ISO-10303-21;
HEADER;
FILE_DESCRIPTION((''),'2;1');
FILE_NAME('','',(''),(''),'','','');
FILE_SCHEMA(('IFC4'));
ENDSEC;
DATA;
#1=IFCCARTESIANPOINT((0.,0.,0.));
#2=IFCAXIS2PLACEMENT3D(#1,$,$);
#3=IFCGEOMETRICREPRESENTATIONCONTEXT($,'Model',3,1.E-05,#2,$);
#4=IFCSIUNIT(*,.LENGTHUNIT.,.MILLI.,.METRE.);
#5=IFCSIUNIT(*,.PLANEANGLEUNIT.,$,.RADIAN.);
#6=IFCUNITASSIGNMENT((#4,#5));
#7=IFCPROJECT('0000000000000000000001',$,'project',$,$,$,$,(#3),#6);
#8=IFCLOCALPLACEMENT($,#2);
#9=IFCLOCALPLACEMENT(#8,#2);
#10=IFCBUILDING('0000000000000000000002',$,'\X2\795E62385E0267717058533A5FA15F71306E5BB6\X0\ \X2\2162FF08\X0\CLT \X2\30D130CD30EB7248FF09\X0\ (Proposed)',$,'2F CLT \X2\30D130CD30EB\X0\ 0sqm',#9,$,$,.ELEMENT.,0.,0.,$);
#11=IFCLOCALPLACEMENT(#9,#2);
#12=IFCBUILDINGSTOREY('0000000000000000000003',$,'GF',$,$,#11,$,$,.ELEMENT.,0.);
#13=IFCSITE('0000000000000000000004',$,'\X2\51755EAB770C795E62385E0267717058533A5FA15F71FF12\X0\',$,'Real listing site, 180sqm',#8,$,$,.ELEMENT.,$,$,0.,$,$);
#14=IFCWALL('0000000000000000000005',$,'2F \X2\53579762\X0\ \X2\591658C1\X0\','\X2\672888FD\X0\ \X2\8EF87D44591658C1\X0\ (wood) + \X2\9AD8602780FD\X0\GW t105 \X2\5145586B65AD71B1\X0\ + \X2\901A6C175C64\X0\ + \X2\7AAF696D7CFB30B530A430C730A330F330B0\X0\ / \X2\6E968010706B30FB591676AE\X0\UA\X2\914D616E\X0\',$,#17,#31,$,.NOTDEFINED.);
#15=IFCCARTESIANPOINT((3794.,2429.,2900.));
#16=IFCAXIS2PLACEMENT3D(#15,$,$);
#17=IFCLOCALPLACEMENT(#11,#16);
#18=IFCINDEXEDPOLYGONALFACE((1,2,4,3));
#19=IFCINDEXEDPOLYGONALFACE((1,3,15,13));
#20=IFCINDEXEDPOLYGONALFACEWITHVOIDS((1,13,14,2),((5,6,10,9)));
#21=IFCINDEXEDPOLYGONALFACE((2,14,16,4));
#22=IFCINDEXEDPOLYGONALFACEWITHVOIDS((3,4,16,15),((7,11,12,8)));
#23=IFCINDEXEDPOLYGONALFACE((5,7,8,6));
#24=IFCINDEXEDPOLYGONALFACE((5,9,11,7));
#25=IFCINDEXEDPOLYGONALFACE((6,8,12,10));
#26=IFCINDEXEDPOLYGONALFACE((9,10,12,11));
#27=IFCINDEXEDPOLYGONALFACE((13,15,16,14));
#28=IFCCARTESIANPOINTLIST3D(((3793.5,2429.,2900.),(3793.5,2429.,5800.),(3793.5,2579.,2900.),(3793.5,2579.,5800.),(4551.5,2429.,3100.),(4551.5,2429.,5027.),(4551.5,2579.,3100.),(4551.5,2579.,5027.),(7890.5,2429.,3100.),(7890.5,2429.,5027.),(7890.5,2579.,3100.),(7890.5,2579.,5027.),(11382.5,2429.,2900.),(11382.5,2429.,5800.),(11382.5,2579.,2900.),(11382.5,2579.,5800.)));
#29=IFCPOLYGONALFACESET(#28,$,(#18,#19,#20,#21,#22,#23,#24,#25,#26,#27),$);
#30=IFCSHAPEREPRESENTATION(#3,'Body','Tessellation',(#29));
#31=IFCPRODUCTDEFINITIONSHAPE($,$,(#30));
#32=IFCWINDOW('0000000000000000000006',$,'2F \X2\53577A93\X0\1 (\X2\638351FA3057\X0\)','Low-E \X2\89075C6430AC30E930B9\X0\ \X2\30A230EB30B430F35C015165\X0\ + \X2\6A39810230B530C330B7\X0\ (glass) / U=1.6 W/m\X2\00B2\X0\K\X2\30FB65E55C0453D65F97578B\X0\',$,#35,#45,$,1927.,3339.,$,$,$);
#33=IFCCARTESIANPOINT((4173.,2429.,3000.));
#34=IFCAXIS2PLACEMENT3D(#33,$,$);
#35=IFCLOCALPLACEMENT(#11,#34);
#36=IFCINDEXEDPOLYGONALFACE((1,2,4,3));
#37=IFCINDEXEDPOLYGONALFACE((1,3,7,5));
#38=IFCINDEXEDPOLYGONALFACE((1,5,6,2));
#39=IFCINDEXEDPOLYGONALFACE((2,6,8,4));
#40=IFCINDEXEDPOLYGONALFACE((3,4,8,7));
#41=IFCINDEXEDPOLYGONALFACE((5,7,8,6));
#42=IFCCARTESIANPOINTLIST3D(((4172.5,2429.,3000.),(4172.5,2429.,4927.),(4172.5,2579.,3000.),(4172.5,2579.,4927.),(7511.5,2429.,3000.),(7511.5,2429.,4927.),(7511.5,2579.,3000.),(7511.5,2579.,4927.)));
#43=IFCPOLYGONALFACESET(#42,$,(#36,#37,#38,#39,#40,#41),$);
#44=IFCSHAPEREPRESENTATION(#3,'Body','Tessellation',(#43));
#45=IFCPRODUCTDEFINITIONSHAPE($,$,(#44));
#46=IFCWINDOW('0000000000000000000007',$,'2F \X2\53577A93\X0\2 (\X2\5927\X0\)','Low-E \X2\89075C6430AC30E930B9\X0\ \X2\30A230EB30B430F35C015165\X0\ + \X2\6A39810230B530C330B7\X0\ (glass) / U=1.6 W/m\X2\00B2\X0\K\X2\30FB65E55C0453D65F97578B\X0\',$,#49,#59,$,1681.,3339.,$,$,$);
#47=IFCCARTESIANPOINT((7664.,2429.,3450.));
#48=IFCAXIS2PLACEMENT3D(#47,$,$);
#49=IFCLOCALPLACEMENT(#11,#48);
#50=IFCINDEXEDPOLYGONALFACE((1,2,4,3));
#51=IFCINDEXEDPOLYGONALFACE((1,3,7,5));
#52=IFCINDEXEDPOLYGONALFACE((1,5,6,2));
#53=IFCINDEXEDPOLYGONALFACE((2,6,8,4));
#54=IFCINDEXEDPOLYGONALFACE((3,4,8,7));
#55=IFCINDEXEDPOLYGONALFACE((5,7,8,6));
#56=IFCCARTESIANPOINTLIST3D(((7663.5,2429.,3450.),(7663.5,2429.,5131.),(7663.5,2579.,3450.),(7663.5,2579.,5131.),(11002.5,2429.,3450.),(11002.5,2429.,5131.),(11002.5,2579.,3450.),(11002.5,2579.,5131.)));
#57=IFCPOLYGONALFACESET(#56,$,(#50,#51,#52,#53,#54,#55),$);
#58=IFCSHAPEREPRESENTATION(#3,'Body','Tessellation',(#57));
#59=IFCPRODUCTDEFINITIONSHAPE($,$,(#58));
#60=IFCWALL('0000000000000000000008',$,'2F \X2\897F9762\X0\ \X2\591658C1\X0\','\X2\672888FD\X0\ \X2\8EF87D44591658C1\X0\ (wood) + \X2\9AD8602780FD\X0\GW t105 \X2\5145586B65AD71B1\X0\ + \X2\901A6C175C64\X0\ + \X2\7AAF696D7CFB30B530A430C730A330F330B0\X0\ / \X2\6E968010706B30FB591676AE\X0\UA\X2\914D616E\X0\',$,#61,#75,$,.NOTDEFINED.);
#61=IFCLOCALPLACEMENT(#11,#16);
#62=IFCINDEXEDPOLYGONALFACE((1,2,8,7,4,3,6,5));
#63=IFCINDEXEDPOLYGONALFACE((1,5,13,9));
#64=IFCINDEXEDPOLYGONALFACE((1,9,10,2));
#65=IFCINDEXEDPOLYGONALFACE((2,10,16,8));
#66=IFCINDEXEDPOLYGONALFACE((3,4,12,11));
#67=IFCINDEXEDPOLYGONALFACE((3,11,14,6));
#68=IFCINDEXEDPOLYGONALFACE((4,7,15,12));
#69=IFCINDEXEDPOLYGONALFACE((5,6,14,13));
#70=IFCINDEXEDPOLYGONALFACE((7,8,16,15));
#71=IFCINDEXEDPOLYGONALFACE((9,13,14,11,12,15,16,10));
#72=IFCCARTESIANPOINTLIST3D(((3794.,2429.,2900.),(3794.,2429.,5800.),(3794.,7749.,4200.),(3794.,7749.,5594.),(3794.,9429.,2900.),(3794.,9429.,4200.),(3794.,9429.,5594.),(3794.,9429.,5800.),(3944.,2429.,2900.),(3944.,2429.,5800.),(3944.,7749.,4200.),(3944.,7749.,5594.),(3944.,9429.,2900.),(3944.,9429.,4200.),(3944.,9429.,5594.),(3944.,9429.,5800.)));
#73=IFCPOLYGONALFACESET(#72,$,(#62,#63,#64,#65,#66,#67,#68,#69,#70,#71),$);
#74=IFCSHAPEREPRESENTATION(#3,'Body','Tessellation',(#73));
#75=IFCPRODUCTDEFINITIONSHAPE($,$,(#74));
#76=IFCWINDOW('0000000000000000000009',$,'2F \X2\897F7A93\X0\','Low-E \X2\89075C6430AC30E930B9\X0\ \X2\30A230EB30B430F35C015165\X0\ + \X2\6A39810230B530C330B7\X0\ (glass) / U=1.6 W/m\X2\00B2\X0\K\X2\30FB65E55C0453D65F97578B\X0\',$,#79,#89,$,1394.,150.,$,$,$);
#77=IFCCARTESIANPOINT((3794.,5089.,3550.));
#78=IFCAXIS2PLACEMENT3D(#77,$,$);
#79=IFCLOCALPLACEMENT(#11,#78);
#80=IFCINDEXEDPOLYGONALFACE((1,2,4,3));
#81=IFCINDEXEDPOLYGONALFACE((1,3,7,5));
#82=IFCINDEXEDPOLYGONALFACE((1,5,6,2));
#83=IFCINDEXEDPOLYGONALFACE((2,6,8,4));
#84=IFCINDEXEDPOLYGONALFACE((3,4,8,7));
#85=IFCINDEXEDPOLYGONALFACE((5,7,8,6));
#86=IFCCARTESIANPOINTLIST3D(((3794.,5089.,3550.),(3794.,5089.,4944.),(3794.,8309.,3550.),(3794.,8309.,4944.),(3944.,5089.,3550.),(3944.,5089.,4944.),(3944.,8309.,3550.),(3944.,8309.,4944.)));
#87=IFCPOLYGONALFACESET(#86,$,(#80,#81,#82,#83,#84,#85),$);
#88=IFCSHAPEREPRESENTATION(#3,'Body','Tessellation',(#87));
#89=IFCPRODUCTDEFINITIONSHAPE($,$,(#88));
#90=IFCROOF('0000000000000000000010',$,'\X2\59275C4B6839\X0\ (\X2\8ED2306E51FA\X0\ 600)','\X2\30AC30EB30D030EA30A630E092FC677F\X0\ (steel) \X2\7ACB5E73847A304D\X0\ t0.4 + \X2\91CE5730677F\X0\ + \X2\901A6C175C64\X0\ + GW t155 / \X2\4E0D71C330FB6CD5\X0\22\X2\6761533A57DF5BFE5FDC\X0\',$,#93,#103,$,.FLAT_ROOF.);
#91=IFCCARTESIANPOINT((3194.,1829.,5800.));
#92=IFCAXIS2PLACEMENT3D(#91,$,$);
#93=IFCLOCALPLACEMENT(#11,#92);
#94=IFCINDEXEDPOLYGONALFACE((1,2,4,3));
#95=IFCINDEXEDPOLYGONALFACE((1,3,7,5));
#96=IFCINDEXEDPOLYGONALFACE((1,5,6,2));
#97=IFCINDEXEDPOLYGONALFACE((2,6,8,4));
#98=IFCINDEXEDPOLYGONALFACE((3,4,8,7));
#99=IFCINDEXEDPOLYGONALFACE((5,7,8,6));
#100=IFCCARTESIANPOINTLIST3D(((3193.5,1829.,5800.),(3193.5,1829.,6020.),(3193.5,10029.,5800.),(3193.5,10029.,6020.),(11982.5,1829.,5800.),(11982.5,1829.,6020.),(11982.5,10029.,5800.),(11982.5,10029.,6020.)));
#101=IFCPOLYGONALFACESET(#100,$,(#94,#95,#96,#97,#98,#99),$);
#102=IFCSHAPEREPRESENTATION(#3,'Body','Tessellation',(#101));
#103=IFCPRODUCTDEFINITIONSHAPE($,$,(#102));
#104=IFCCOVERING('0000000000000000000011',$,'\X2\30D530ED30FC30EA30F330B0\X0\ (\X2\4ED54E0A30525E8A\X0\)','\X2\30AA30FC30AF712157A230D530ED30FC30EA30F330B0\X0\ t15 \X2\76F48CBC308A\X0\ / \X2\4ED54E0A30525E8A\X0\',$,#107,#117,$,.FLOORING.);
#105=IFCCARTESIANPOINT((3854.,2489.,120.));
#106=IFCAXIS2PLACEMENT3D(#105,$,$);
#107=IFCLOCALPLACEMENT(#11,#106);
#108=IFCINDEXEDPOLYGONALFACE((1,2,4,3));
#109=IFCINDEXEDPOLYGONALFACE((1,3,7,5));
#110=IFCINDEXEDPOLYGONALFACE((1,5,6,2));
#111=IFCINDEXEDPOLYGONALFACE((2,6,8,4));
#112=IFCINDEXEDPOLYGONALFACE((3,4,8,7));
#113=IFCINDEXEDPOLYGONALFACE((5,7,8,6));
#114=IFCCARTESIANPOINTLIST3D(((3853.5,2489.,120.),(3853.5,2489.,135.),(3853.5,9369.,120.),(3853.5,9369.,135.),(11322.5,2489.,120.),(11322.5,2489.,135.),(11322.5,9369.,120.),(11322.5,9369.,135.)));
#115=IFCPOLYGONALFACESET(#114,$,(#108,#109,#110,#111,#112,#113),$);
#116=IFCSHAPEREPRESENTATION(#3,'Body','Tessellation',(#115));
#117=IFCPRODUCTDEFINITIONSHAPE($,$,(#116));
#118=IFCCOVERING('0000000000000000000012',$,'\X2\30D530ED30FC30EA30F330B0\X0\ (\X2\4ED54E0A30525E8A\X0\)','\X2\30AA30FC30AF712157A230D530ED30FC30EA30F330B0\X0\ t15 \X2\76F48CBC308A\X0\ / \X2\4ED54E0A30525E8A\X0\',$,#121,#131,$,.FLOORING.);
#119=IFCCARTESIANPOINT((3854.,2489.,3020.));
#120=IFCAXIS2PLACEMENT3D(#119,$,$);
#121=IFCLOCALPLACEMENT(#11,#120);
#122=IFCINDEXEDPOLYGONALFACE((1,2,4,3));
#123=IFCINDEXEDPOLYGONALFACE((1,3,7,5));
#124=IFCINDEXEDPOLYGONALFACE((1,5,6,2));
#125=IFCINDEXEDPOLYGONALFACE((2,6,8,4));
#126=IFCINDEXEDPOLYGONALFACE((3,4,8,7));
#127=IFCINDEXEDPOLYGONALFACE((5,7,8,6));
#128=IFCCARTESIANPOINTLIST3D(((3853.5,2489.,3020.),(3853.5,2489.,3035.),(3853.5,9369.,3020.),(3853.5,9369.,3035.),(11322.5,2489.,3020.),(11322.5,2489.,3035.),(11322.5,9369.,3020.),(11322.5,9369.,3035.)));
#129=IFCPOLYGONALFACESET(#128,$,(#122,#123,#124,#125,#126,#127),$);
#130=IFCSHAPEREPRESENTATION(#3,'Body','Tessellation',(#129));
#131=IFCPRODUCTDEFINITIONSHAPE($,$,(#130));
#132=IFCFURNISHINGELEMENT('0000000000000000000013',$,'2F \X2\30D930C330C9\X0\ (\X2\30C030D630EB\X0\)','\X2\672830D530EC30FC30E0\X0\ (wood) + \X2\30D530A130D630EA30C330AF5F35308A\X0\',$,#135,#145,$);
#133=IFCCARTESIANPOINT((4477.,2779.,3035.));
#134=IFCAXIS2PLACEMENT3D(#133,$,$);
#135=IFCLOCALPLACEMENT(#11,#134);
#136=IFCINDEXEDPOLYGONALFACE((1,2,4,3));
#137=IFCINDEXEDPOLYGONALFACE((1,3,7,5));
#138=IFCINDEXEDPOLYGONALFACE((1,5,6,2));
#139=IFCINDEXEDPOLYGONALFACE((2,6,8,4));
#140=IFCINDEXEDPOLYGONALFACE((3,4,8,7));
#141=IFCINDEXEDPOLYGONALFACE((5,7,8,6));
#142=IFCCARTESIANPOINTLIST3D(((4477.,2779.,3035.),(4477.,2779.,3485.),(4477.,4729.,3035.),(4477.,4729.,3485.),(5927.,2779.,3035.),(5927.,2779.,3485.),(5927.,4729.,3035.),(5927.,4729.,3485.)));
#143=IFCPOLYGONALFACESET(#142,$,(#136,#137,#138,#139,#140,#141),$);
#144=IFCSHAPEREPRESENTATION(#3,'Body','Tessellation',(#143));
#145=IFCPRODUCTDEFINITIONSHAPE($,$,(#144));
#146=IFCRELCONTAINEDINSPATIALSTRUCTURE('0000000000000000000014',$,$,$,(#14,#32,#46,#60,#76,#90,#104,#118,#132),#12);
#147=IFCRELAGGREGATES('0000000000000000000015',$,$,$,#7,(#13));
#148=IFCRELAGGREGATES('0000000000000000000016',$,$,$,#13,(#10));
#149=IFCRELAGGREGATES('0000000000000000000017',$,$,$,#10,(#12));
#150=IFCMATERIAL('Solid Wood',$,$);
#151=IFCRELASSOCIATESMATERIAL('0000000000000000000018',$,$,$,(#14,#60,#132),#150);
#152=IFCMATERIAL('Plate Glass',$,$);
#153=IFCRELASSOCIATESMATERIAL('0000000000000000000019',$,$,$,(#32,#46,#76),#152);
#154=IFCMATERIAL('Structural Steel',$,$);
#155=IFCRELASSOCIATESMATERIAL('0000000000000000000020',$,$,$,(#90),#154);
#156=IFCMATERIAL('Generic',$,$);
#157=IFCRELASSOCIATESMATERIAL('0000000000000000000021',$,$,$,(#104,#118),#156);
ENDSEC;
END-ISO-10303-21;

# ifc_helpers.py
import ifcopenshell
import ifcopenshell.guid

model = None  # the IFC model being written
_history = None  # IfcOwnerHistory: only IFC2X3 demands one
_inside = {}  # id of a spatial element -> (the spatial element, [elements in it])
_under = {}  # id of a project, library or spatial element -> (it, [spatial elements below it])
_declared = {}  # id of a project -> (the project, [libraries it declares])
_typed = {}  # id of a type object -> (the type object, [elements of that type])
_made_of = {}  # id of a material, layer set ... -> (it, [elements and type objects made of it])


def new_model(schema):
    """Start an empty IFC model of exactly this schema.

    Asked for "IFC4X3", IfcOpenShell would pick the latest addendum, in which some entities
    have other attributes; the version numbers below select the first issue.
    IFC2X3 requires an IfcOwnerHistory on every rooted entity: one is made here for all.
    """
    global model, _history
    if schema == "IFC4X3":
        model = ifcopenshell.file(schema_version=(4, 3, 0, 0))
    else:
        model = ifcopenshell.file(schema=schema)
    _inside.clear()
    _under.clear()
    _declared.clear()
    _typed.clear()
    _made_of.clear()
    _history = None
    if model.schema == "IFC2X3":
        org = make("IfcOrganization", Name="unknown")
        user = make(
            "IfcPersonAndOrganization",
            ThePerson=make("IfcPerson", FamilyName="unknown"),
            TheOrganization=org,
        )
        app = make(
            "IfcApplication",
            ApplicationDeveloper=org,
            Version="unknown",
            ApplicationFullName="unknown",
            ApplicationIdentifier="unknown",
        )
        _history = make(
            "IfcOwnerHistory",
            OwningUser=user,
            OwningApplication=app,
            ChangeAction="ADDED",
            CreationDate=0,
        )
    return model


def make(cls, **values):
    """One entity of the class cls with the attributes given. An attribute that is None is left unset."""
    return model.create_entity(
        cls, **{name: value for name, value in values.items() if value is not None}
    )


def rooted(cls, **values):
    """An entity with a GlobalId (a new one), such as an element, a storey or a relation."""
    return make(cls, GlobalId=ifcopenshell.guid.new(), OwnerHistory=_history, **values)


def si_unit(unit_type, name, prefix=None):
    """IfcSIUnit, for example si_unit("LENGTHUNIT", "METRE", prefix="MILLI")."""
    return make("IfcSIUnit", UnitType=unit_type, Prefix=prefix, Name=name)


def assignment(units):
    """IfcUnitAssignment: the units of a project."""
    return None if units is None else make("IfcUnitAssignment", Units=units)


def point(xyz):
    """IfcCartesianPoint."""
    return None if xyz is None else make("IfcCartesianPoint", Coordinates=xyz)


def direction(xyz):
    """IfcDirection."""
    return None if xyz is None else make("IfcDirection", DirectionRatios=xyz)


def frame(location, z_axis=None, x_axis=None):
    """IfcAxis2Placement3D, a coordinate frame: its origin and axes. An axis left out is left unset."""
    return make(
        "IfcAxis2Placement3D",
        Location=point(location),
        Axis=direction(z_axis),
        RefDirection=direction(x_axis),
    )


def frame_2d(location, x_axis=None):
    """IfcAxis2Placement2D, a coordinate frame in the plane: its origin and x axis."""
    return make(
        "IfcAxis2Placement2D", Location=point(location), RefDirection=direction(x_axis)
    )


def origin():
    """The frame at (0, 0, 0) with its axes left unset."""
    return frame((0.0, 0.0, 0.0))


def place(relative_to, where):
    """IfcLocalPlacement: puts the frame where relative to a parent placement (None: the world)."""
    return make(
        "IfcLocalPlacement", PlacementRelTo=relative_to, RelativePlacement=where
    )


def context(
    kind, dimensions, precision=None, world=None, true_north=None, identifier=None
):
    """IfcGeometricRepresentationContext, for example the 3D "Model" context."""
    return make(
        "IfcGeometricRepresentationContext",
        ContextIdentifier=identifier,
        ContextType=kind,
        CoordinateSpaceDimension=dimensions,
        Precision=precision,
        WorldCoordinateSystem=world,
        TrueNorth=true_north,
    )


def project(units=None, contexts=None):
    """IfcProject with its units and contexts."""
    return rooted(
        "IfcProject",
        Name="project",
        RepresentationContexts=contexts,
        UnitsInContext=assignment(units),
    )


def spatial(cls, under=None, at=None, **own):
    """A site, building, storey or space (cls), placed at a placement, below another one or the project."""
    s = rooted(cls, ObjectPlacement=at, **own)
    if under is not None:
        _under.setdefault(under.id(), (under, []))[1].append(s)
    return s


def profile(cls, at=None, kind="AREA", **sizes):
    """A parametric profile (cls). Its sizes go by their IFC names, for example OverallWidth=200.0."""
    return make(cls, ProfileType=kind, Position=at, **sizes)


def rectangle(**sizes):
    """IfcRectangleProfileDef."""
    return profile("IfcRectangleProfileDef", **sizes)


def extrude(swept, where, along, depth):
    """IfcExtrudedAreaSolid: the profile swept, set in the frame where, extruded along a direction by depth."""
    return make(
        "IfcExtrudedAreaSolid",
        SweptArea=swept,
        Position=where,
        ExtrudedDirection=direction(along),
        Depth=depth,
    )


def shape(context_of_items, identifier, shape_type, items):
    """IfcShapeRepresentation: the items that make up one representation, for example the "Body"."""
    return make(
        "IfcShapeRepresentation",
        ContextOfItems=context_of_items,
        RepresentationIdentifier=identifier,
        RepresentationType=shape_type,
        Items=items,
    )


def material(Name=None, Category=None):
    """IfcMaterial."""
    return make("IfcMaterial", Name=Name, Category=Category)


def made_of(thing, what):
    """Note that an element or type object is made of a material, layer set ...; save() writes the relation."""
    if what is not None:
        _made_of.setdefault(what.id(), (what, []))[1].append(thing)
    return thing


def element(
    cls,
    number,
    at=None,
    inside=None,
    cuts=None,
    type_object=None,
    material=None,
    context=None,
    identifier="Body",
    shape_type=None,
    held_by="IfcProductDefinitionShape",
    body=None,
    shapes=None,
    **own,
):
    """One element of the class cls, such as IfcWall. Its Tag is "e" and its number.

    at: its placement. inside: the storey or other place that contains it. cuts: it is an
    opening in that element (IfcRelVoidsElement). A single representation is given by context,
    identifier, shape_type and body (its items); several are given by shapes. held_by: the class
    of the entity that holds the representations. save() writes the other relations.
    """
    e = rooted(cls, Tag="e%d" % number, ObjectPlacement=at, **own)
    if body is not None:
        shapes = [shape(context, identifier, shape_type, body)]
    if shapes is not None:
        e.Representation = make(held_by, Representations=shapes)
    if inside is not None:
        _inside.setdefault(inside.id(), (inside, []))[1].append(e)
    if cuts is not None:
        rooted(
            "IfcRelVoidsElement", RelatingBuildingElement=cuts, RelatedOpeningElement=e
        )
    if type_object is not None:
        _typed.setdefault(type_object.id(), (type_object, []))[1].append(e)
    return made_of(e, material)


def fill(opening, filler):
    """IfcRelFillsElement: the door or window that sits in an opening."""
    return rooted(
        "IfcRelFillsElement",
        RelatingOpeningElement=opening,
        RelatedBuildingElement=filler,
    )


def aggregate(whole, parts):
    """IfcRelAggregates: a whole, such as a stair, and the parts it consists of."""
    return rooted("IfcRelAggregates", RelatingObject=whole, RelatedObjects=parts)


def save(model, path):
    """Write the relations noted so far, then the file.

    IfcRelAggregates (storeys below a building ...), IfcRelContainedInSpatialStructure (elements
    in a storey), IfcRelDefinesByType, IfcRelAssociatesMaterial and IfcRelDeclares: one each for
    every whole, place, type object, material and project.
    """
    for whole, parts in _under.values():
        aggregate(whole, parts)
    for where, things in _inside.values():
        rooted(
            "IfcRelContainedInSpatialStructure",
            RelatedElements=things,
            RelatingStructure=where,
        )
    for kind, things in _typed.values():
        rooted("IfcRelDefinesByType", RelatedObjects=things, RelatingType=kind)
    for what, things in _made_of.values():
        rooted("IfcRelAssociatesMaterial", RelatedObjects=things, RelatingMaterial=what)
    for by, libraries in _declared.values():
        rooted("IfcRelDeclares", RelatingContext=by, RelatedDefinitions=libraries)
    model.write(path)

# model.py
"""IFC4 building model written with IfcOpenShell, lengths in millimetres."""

from ifc_helpers import new_model, si_unit, frame, frame_2d, origin, place, context, project, spatial, rectangle, extrude, material, element, fill, save


model = new_model("IFC4")

# Units and contexts
model_context = context("Model", 3, precision=1e-05, world=origin())
ifc_project = project(units=[si_unit("LENGTHUNIT", "METRE", prefix="MILLI"), si_unit("PLANEANGLEUNIT", "RADIAN")], contexts=[model_context])

# Site, building, storey
site_placement = place(None, origin())
site = spatial("IfcSite", under=ifc_project, at=site_placement, Name="兵庫県神戸市東灘区御影２", ObjectType="Real listing site, 180sqm", CompositionType="ELEMENT", RefElevation=0.0)
building_placement = place(site_placement, origin())
building = spatial("IfcBuilding", under=site, at=building_placement, Name="神戸市東灘区御影の家 Ⅲ（CLT パネル版） (Proposed)", ObjectType="2F CLT パネル 0sqm", CompositionType="ELEMENT", ElevationOfRefHeight=0.0, ElevationOfTerrain=0.0)
storey_placement = place(building_placement, origin())
storey = spatial("IfcBuildingStorey", under=building, at=storey_placement, Name="GF", CompositionType="ELEMENT", Elevation=0.0)

# Shared definitions
ifc_material_1 = material(Name="Solid Wood")

# Shared definitions
ifc_material_2 = material(Name="Plate Glass")

# Wall, openings, windows
wall_1_placement = place(storey_placement, frame((3794.0, 2429.0, 2900.0)))
wall_1 = element("IfcWall", 1, at=wall_1_placement, inside=storey, material=ifc_material_1, Name="2F 南面 外壁", Description="木製 軸組外壁 (wood) + 高性能GW t105 充填断熱 + 通気層 + 窯業系サイディング / 準耐火・外皮UA配慮", PredefinedType="NOTDEFINED", context=model_context, shape_type="SweptSolid", body=[
    extrude(rectangle(XDim=7589.0, YDim=150.0, at=frame_2d((3794.0, 75.0))), frame((3794.0, 2429.0, 2900.0)), (0.0, 0.0, 1.0), 2900.0),
])
opening_1_placement = place(storey_placement, frame((4173.0, 2429.0, 3000.0)))
opening_1 = element("IfcOpeningElement", 2, at=opening_1_placement, cuts=wall_1, PredefinedType="NOTDEFINED", context=model_context, shape_type="SweptSolid", body=[
    extrude(rectangle(XDim=3339.0, YDim=150.0, at=frame_2d((1669.0, 75.0))), frame((4173.0, 2429.0, 3000.0)), (0.0, 0.0, 1.0), 1927.0),
])
opening_2_placement = place(storey_placement, frame((7664.0, 2429.0, 3450.0)))
opening_2 = element("IfcOpeningElement", 3, at=opening_2_placement, cuts=wall_1, PredefinedType="NOTDEFINED", context=model_context, shape_type="SweptSolid", body=[
    extrude(rectangle(XDim=3339.0, YDim=150.0, at=frame_2d((1669.0, 75.0))), frame((7664.0, 2429.0, 3450.0)), (0.0, 0.0, 1.0), 1681.0),
])
window_1_placement = place(storey_placement, frame((4173.0, 2429.0, 3000.0)))
window_1 = element("IfcWindow", 4, at=window_1_placement, inside=storey, material=ifc_material_2, Name="2F 南窓1 (掃出し)", Description="Low-E 複層ガラス アルゴン封入 + 樹脂サッシ (glass) / U=1.6 W/m²K・日射取得型", OverallHeight=1927.0, OverallWidth=3339.0, context=model_context, shape_type="SweptSolid", body=[
    extrude(rectangle(XDim=3339.0, YDim=150.0, at=frame_2d((1669.0, 75.0))), frame((4173.0, 2429.0, 3000.0)), (0.0, 0.0, 1.0), 1927.0),
])
fill(opening_1, window_1)
window_2_placement = place(storey_placement, frame((7664.0, 2429.0, 3450.0)))
window_2 = element("IfcWindow", 5, at=window_2_placement, inside=storey, material=ifc_material_2, Name="2F 南窓2 (大)", Description="Low-E 複層ガラス アルゴン封入 + 樹脂サッシ (glass) / U=1.6 W/m²K・日射取得型", OverallHeight=1681.0, OverallWidth=3339.0, context=model_context, shape_type="SweptSolid", body=[
    extrude(rectangle(XDim=3339.0, YDim=150.0, at=frame_2d((1669.0, 75.0))), frame((7664.0, 2429.0, 3450.0)), (0.0, 0.0, 1.0), 1681.0),
])
fill(opening_2, window_2)

# Wall, opening, window
wall_2_placement = place(storey_placement, frame((3794.0, 2429.0, 2900.0)))
wall_2 = element("IfcWall", 6, at=wall_2_placement, inside=storey, material=ifc_material_1, Name="2F 西面 外壁", Description="木製 軸組外壁 (wood) + 高性能GW t105 充填断熱 + 通気層 + 窯業系サイディング / 準耐火・外皮UA配慮", PredefinedType="NOTDEFINED", context=model_context, shape_type="SweptSolid", body=[
    extrude(rectangle(XDim=150.0, YDim=7000.0, at=frame_2d((75.0, 3500.0))), frame((3794.0, 2429.0, 2900.0)), (0.0, 0.0, 1.0), 2900.0),
])
opening_3_placement = place(storey_placement, frame((3794.0, 5089.0, 3550.0)))
opening_3 = element("IfcOpeningElement", 7, at=opening_3_placement, cuts=wall_2, PredefinedType="NOTDEFINED", context=model_context, shape_type="SweptSolid", body=[
    extrude(rectangle(XDim=150.0, YDim=3220.0, at=frame_2d((75.0, 1610.0))), frame((3794.0, 5089.0, 3550.0)), (0.0, 0.0, 1.0), 1394.0),
])
window_3_placement = place(storey_placement, frame((3794.0, 5089.0, 3550.0)))
window_3 = element("IfcWindow", 8, at=window_3_placement, inside=storey, material=ifc_material_2, Name="2F 西窓", Description="Low-E 複層ガラス アルゴン封入 + 樹脂サッシ (glass) / U=1.6 W/m²K・日射取得型", OverallHeight=1394.0, OverallWidth=150.0, context=model_context, shape_type="SweptSolid", body=[
    extrude(rectangle(XDim=150.0, YDim=3220.0, at=frame_2d((75.0, 1610.0))), frame((3794.0, 5089.0, 3550.0)), (0.0, 0.0, 1.0), 1394.0),
])
fill(opening_3, window_3)

# Roof
ifc_material_3 = material(Name="Structural Steel")
roof_placement = place(storey_placement, frame((3194.0, 1829.0, 5800.0)))
element("IfcRoof", 9, at=roof_placement, inside=storey, material=ifc_material_3, Name="大屋根 (軒の出 600)", Description="ガルバリウム鋼板 (steel) 立平葺き t0.4 + 野地板 + 通気層 + GW t155 / 不燃・法22条区域対応", PredefinedType="FLAT_ROOF", context=model_context, shape_type="SweptSolid", body=[
    extrude(rectangle(XDim=8789.0, YDim=8200.0, at=frame_2d((4394.0, 4100.0))), frame((3194.0, 1829.0, 5800.0)), (0.0, 0.0, 1.0), 220.0),
])

# Coverings
ifc_material_4 = material(Name="Generic")
covering_1_placement = place(storey_placement, frame((3854.0, 2489.0, 120.0)))
element("IfcCovering", 10, at=covering_1_placement, inside=storey, material=ifc_material_4, Name="フローリング (仕上げ床)", Description="オーク無垢フローリング t15 直貼り / 仕上げ床", PredefinedType="FLOORING", context=model_context, shape_type="SweptSolid", body=[
    extrude(rectangle(XDim=7469.0, YDim=6880.0, at=frame_2d((3734.0, 3440.0))), frame((3854.0, 2489.0, 120.0)), (0.0, 0.0, 1.0), 15.0),
])
covering_2_placement = place(storey_placement, frame((3854.0, 2489.0, 3020.0)))
element("IfcCovering", 11, at=covering_2_placement, inside=storey, material=ifc_material_4, Name="フローリング (仕上げ床)", Description="オーク無垢フローリング t15 直貼り / 仕上げ床", PredefinedType="FLOORING", context=model_context, shape_type="SweptSolid", body=[
    extrude(rectangle(XDim=7469.0, YDim=6880.0, at=frame_2d((3734.0, 3440.0))), frame((3854.0, 2489.0, 3020.0)), (0.0, 0.0, 1.0), 15.0),
])

# Furnishing element
furnishing_placement = place(storey_placement, frame((4477.0, 2779.0, 3035.0)))
element("IfcFurnishingElement", 12, at=furnishing_placement, inside=storey, material=ifc_material_1, Name="2F ベッド (ダブル)", Description="木フレーム (wood) + ファブリック張り", context=model_context, shape_type="SweptSolid", body=[
    extrude(rectangle(XDim=1450.0, YDim=1950.0, at=frame_2d((725.0, 975.0))), frame((4477.0, 2779.0, 3035.0)), (0.0, 0.0, 1.0), 450.0),
])

save(model, "model.ifc")
